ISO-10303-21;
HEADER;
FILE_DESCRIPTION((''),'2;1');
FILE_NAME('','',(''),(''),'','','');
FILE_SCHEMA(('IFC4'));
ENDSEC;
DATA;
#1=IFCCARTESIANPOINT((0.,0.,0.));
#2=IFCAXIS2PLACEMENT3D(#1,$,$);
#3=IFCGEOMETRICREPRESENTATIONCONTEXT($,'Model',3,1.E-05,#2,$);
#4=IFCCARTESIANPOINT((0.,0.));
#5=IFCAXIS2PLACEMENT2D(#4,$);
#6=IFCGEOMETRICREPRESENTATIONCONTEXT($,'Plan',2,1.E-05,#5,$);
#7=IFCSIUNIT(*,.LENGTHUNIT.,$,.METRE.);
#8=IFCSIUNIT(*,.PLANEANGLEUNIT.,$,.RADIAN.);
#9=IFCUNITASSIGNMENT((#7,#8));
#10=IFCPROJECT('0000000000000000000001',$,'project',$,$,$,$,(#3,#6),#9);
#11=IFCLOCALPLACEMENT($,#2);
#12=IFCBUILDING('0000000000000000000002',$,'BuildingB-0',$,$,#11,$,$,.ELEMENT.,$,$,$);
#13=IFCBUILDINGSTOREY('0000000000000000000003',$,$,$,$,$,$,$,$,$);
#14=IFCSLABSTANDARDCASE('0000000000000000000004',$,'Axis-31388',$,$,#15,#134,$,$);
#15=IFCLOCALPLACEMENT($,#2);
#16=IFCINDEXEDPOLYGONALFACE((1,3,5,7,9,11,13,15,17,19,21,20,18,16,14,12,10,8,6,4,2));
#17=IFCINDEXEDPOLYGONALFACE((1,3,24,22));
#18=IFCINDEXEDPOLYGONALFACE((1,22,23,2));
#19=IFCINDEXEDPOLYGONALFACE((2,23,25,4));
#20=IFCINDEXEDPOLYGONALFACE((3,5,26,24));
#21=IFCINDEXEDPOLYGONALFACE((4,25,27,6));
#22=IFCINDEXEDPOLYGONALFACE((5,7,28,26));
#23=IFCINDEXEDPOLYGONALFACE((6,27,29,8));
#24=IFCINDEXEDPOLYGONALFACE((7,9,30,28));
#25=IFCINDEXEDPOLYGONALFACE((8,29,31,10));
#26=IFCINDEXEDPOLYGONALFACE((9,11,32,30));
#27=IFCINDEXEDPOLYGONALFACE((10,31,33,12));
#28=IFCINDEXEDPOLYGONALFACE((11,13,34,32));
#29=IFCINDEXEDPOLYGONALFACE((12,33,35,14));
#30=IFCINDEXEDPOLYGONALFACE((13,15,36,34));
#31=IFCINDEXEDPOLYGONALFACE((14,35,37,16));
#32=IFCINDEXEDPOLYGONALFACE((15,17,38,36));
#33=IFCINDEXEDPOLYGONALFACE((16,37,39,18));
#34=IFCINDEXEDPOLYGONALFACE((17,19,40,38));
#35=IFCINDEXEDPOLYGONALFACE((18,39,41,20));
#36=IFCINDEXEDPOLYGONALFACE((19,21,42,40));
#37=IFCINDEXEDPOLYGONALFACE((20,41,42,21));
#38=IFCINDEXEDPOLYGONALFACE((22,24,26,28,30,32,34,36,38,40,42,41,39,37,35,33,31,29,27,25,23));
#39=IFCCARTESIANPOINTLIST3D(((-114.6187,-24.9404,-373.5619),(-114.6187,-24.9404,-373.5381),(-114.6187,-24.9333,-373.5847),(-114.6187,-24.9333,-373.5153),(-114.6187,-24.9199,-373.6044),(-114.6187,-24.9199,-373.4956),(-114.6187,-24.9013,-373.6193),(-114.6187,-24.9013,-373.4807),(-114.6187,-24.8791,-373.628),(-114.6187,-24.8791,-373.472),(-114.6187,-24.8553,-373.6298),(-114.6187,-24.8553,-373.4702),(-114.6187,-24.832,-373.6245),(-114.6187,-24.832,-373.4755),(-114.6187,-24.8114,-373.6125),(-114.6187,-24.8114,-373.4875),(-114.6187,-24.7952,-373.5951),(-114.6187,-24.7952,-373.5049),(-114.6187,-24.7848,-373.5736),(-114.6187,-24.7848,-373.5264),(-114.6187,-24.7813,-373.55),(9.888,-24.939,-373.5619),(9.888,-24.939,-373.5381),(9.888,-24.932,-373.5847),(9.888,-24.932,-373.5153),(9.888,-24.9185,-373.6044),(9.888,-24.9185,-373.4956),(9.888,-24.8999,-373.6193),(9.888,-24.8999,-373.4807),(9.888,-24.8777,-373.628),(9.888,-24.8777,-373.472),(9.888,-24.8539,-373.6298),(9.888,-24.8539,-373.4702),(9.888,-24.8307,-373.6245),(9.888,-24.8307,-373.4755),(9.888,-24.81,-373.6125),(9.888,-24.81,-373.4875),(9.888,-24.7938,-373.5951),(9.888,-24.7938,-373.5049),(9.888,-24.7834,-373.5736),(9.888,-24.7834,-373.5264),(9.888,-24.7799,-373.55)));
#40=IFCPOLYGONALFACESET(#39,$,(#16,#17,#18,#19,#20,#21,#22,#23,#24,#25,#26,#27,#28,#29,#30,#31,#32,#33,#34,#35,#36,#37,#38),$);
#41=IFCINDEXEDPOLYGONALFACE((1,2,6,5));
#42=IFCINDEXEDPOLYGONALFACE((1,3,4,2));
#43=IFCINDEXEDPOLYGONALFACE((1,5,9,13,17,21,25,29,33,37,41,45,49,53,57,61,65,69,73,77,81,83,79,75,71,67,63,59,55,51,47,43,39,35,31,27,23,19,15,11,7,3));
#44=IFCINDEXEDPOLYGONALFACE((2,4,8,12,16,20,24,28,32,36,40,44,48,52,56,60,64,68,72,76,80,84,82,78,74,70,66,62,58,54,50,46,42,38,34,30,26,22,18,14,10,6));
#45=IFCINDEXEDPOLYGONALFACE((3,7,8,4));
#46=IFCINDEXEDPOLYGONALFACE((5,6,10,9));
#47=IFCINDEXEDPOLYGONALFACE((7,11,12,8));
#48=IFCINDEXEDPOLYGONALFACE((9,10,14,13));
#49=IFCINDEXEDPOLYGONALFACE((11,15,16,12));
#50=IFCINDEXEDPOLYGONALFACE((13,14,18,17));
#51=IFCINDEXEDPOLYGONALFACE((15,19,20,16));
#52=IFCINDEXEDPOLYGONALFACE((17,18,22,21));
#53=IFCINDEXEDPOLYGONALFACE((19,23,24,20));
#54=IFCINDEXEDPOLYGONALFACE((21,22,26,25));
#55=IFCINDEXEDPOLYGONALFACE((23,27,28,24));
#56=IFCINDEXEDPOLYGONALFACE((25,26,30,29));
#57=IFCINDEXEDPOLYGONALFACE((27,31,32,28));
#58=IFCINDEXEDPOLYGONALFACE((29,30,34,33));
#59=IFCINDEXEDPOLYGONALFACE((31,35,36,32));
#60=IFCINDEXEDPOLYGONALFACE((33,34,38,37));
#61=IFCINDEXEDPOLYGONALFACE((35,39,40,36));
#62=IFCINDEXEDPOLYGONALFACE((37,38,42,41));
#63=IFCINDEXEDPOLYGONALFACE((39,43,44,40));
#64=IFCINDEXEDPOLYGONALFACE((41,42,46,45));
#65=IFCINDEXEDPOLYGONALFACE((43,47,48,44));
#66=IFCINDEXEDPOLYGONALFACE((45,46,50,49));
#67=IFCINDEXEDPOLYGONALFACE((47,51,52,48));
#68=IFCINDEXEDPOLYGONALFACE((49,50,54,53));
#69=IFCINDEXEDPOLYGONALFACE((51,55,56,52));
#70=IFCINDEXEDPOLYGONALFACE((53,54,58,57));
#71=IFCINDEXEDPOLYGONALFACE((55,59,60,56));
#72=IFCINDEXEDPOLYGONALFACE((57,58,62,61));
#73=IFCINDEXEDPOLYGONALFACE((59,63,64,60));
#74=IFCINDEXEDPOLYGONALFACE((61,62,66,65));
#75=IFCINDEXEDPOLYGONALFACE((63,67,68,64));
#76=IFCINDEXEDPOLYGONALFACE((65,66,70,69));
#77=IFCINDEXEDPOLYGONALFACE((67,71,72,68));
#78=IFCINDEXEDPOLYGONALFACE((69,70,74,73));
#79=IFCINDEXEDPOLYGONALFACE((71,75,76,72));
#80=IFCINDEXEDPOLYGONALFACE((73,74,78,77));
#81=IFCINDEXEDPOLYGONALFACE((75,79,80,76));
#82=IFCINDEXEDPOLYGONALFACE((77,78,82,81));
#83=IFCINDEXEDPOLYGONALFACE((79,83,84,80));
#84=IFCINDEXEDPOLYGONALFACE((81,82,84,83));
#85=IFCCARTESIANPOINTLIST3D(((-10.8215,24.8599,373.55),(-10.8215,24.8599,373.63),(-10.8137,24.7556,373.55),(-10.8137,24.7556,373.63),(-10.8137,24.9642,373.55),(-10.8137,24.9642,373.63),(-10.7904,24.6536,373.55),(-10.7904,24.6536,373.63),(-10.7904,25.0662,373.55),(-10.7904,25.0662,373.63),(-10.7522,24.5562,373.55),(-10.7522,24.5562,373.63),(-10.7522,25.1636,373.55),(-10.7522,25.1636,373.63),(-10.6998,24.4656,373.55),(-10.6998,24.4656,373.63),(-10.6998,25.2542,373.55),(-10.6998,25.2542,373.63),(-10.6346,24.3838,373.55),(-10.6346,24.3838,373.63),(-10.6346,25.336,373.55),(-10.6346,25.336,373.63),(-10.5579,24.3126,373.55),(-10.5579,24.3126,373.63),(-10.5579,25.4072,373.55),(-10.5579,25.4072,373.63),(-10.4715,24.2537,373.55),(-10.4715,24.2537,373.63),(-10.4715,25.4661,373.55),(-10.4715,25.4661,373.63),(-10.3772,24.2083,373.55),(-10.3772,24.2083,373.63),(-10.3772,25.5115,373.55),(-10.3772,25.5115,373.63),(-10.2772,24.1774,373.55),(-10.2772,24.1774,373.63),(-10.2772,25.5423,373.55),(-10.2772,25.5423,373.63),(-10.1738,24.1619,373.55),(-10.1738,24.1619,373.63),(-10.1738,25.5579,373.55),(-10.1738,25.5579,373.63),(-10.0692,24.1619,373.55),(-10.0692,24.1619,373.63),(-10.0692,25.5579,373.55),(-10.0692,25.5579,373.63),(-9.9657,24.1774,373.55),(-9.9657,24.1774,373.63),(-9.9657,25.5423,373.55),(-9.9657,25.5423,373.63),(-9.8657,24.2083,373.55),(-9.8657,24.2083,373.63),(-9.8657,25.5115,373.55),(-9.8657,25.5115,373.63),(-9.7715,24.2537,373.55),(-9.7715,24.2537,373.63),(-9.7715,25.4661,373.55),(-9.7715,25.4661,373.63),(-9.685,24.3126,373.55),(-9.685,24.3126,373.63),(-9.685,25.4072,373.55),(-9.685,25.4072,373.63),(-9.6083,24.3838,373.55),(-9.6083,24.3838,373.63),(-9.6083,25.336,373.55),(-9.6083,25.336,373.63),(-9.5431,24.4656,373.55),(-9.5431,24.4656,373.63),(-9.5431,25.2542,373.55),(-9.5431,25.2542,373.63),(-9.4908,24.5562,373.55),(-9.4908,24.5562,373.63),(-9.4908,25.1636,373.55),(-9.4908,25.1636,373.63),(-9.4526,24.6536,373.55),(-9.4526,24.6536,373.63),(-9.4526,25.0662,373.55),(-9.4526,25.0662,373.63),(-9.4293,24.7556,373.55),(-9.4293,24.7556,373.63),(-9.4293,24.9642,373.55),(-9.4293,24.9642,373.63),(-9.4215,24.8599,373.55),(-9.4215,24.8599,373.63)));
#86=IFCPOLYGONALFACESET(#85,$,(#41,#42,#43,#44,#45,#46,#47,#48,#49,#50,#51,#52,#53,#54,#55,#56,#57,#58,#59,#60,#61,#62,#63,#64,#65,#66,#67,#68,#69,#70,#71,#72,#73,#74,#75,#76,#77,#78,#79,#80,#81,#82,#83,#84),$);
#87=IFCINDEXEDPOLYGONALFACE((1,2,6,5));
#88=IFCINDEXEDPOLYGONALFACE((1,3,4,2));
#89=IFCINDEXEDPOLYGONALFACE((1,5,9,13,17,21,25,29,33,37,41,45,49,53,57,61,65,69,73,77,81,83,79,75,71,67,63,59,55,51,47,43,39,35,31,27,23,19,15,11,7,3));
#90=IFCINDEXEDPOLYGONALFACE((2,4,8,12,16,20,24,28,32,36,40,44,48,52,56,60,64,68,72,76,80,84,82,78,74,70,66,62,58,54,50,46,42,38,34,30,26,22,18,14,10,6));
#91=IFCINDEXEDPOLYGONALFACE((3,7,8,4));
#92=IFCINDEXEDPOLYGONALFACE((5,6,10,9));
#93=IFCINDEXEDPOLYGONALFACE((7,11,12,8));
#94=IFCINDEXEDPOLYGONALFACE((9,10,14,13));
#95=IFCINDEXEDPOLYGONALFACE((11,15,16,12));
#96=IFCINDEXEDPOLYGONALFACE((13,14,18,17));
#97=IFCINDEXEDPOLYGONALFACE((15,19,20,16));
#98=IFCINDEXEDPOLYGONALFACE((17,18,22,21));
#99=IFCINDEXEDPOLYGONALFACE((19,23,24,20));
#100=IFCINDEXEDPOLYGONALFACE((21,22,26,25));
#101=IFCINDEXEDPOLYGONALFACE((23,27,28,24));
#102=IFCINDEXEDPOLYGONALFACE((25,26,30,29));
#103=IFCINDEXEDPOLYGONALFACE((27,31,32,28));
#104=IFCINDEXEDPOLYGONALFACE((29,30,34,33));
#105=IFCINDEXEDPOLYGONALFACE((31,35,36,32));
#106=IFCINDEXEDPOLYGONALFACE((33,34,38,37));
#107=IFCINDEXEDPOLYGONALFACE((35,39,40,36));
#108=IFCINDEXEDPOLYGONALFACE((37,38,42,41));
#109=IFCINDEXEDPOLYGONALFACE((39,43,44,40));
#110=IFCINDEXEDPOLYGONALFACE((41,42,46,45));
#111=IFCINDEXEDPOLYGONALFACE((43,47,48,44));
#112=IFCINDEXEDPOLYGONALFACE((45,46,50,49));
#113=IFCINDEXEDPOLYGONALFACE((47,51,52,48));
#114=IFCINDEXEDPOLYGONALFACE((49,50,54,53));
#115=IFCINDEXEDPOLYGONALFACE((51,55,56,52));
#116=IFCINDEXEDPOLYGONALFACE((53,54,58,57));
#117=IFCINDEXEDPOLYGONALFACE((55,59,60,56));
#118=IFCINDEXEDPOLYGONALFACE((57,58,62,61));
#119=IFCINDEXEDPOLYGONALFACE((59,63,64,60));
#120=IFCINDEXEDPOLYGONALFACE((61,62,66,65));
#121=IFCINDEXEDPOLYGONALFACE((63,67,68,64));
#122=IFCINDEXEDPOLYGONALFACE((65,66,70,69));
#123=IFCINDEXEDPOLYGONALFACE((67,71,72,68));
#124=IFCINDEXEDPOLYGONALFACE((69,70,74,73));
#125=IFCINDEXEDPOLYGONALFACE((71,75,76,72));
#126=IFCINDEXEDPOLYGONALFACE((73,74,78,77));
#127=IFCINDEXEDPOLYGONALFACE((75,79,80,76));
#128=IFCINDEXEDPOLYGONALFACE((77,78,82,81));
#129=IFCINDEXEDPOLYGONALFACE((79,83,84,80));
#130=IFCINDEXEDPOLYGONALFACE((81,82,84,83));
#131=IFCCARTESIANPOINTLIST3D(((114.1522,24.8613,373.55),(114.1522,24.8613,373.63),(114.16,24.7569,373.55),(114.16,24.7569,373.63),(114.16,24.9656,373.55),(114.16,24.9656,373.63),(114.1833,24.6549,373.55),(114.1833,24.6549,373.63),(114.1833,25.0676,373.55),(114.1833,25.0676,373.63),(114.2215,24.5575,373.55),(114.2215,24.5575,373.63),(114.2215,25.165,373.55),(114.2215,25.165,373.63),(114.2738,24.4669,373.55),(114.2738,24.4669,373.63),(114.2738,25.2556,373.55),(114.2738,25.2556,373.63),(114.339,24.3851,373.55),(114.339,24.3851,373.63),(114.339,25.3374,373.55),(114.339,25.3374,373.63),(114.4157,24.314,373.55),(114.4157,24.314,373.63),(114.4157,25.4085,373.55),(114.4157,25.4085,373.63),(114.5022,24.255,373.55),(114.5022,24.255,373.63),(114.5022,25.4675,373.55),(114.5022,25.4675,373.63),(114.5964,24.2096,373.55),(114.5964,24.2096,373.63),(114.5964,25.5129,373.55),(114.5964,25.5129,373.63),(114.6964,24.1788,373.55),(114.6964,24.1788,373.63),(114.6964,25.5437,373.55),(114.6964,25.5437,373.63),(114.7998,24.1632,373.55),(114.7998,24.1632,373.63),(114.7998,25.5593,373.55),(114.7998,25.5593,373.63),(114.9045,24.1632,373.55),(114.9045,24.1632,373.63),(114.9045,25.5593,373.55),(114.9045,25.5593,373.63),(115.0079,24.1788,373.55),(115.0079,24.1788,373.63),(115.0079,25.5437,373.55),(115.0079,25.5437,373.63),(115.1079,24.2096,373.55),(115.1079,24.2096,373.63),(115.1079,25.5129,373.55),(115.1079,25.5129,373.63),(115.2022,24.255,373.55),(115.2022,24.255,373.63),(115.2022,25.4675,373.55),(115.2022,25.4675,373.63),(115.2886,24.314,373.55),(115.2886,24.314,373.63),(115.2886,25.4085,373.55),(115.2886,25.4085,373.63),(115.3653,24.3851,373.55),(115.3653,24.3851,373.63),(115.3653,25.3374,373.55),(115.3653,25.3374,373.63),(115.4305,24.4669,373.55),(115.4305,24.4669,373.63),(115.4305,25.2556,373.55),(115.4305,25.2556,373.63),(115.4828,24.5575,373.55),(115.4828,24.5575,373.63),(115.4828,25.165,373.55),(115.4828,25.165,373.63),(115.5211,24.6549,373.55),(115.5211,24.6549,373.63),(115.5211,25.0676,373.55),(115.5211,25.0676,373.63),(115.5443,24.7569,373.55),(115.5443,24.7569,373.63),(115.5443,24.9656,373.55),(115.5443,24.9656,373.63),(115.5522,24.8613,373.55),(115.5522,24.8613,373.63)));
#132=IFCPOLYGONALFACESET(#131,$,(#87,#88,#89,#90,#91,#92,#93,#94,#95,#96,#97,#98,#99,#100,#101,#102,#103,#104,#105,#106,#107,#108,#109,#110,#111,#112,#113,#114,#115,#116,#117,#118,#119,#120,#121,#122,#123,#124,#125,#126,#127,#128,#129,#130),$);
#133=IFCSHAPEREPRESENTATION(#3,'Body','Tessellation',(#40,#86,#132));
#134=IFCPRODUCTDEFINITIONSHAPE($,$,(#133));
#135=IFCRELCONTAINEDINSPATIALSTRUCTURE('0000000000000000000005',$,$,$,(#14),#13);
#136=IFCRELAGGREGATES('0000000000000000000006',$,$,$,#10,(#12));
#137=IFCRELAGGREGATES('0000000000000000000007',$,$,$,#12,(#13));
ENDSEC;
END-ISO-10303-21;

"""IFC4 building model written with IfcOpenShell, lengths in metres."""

from ifc_helpers import new_model, entity, si_unit, frame, origin, origin_2d, place, context, project, spatial, circle, extrude, element, save


model = new_model("IFC4")

# Units and contexts
model_context = context("Model", 3, precision=1e-05, world=origin())
plan_context = context("Plan", 2, precision=1e-05, world=origin_2d())
ifc_project = project(units=[si_unit("LENGTHUNIT", "METRE"), si_unit("PLANEANGLEUNIT", "RADIAN")], contexts=[model_context, plan_context])

# Building, storey
building_placement = place(None, origin())
building = spatial("IfcBuilding", under=ifc_project, at=building_placement, Name="BuildingB-0", CompositionType="ELEMENT")
storey = spatial("IfcBuildingStorey", under=building)

# Slab
element("IfcSlabStandardCase", 1, inside=storey, Name="Axis-31388", context=model_context, shape_type="AdvancedSweptSolid", body=[
    entity("IfcSurfaceCurveSweptAreaSolid", entity("IfcCircleProfileDef", "AREA", None, None, 0.08), None, entity("IfcPolyline", [entity("IfcCartesianPoint", [-9.888, 24.8599, 373.55]), entity("IfcCartesianPoint", [114.6187, 24.8613, 373.55])]), None, None, entity("IfcPlane", entity("IfcAxis2Placement3D", entity("IfcCartesianPoint", [-9.888, 24.8599, 373.55]), entity("IfcDirection", [0.0, 0.0, 1.0]), entity("IfcDirection", [1.0, 0.0, 0.0])))),
    extrude(circle(Radius=0.7), frame((-10.1215, 24.8599, 373.55)), (0.0, 0.0, 1.0), 0.08),
    extrude(circle(Radius=0.7), frame((114.8522, 24.8613, 373.55)), (0.0, 0.0, 1.0), 0.08),
])

save(model, "model.ifc")
